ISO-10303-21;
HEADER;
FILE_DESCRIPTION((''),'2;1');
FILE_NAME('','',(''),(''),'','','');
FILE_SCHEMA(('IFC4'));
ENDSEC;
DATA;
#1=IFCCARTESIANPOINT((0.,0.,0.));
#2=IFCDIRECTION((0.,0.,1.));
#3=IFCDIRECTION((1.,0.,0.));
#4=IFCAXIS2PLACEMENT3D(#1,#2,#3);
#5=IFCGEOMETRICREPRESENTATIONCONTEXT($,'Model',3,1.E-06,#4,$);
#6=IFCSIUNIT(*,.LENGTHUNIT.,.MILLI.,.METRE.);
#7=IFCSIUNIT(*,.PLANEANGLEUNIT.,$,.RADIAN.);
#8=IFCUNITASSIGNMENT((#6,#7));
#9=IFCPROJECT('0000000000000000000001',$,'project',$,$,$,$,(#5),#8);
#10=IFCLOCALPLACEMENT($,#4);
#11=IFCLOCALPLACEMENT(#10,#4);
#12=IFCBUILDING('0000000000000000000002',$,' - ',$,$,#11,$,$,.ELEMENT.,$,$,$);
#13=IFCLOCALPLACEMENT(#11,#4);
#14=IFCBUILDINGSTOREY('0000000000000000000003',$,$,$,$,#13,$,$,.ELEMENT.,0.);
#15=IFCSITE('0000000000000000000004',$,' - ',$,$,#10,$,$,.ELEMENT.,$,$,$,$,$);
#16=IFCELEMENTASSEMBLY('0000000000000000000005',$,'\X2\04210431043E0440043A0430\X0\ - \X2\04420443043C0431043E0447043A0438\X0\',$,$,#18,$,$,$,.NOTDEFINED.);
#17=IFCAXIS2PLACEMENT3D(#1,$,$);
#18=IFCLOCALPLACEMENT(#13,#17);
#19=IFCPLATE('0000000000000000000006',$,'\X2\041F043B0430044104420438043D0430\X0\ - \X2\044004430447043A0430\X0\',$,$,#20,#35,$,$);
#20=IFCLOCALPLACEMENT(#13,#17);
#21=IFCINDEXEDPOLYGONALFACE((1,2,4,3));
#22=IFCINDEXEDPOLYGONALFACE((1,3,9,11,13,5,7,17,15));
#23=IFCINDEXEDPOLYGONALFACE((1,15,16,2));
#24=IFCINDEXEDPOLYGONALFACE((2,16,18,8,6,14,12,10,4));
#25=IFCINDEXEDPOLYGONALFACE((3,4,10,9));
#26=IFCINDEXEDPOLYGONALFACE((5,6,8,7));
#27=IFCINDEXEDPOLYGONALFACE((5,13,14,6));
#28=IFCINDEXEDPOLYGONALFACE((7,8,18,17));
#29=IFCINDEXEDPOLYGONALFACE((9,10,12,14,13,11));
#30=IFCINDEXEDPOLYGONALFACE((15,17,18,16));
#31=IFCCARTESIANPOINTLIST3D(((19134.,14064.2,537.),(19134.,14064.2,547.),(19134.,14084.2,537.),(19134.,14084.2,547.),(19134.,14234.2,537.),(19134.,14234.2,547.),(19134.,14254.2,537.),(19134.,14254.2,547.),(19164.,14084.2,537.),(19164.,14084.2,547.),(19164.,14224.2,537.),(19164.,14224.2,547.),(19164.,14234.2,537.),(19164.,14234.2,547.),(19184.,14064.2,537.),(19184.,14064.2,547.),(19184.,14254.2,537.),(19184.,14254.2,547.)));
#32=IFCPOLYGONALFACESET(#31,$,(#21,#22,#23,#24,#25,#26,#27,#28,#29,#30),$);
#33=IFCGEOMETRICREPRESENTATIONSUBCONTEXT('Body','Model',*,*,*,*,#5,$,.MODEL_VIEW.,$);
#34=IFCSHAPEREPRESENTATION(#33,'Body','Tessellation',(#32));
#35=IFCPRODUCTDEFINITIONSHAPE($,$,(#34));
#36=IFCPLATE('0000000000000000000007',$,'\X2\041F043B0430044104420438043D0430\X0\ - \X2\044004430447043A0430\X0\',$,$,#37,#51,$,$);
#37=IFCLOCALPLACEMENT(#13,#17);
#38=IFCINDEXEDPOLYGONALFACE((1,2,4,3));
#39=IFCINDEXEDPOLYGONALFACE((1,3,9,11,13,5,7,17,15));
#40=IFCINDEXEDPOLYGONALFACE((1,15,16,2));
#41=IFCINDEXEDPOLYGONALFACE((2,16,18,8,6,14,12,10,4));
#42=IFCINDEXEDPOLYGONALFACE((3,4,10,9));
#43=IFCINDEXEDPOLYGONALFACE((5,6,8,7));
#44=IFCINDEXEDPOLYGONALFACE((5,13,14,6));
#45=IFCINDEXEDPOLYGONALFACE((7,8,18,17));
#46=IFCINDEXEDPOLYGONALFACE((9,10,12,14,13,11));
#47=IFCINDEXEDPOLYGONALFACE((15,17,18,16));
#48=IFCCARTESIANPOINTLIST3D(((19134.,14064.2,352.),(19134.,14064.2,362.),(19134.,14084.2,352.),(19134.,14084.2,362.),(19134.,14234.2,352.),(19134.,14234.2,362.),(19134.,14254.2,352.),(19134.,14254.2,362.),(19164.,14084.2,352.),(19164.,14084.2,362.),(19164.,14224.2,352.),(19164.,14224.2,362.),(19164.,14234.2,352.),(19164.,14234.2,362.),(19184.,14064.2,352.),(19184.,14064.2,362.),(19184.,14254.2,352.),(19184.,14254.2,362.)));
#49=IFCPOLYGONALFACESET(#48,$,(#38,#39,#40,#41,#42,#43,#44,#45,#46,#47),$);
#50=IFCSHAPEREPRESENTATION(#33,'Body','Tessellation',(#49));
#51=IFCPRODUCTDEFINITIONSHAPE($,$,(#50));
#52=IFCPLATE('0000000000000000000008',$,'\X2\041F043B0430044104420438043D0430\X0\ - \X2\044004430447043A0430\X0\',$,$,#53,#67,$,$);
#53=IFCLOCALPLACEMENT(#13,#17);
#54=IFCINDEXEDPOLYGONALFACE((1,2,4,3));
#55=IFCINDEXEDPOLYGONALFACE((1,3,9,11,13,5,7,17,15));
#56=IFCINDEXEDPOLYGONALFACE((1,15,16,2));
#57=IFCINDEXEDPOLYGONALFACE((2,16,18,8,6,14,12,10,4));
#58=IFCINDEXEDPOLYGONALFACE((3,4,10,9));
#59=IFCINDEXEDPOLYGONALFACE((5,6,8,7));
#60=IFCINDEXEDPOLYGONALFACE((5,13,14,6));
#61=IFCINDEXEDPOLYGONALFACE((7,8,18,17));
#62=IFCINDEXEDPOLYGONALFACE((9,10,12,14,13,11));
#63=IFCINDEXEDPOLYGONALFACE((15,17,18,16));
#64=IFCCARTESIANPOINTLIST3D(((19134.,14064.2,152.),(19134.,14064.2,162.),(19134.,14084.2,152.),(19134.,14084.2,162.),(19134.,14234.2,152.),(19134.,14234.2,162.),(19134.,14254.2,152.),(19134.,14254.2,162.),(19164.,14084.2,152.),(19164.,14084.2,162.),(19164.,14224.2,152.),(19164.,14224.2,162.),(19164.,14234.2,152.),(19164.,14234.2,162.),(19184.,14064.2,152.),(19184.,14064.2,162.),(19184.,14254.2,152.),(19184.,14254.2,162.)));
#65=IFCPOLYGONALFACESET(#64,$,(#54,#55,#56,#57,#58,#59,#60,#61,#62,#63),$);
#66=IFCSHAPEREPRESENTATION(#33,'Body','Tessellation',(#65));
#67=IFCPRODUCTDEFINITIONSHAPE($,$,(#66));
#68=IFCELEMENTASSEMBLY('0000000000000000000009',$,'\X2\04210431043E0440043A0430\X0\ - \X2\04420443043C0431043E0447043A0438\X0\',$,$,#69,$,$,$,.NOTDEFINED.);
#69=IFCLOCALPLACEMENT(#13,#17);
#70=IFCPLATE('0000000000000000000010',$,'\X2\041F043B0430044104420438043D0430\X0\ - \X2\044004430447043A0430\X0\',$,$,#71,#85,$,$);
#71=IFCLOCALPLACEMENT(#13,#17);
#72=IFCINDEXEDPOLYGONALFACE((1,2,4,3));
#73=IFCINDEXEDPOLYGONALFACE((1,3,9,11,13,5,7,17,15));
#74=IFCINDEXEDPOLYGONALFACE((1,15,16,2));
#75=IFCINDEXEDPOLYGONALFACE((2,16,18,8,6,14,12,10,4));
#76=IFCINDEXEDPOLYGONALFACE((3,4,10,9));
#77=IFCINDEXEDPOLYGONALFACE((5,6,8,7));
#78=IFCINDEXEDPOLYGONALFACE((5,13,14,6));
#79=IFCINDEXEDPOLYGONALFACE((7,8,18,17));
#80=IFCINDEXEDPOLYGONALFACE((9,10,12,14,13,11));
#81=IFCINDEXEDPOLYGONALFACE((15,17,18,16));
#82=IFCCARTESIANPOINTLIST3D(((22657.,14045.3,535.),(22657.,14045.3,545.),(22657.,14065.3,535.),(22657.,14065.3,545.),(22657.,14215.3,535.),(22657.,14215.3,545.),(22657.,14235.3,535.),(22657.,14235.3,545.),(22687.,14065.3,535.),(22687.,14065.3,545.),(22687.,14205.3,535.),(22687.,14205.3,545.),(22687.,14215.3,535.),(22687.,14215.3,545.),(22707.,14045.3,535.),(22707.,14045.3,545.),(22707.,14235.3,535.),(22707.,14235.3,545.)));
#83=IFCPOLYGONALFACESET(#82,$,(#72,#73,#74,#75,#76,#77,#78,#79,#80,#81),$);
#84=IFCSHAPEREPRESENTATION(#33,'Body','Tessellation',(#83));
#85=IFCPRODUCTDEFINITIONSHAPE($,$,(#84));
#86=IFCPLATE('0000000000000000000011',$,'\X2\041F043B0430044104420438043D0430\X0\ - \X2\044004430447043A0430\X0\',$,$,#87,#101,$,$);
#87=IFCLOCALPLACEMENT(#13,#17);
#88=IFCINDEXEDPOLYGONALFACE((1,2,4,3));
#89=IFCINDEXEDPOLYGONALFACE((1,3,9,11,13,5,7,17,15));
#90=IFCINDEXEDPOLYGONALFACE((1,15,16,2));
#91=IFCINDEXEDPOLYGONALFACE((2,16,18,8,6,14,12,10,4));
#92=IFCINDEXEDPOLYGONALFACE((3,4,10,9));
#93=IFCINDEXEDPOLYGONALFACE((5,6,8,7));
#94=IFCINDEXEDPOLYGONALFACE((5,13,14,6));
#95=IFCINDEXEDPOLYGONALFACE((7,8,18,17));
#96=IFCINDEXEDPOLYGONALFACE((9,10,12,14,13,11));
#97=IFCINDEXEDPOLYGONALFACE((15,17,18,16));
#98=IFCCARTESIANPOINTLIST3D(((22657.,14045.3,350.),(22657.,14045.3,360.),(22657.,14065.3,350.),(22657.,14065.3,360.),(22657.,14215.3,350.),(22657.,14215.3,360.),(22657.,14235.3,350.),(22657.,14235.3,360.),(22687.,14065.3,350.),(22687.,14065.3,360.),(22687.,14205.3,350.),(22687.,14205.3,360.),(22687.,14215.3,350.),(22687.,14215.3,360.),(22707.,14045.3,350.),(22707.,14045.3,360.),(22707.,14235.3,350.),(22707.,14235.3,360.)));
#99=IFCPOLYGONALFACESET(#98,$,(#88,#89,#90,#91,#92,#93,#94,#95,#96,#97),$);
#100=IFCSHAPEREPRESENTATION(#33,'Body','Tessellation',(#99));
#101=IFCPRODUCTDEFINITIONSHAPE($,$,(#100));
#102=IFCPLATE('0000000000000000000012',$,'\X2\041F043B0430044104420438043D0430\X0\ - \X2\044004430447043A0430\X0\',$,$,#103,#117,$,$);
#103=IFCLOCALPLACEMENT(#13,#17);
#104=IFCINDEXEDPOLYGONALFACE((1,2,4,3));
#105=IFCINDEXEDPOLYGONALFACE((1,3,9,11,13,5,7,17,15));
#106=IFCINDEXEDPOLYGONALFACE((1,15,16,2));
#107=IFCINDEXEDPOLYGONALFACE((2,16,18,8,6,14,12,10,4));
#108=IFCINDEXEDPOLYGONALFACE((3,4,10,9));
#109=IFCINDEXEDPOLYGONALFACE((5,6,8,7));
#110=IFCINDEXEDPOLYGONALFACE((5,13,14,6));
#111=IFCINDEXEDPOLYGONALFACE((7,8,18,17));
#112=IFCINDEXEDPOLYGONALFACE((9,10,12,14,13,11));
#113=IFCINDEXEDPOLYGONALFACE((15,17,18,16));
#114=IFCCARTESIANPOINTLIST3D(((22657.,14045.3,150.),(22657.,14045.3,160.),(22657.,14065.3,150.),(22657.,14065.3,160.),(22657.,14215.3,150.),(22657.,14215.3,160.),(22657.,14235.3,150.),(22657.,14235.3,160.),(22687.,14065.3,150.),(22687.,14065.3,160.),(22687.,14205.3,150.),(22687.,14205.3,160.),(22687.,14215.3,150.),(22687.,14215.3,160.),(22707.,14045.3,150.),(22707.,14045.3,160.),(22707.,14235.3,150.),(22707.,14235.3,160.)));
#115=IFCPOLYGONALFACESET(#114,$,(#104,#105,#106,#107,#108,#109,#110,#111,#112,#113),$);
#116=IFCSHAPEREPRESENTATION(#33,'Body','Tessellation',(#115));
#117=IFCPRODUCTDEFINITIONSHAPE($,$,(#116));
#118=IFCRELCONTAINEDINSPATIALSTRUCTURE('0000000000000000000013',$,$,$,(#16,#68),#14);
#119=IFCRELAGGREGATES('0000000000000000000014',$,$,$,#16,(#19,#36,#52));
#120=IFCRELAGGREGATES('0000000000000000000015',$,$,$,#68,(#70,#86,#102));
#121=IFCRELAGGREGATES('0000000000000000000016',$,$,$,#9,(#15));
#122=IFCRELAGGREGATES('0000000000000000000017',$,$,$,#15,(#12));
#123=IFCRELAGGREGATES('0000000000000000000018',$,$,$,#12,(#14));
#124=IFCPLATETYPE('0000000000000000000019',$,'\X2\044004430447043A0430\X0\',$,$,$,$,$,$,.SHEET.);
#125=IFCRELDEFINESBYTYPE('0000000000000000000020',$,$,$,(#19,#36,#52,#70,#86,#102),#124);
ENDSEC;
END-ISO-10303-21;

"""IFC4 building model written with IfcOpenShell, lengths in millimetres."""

from ifc_helpers import new_model, si_unit, frame, origin_with_axes, place, context, subcontext, project, spatial, line, indexed_curve, outline, extrude, source, transform, mapped, type_object, element, aggregate, save


model = new_model("IFC4")

# Units and contexts
model_context = context("Model", 3, precision=1e-06, world=origin_with_axes())
body_context = subcontext(model_context, "Body", "Model", "MODEL_VIEW")
ifc_project = project(units=[si_unit("LENGTHUNIT", "METRE", prefix="MILLI"), si_unit("PLANEANGLEUNIT", "RADIAN")], contexts=[model_context])

# Site, building, storey
site_placement = place(None, origin_with_axes())
site = spatial("IfcSite", under=ifc_project, at=site_placement, Name=" - ", CompositionType="ELEMENT")
building_placement = place(site_placement, origin_with_axes())
building = spatial("IfcBuilding", under=site, at=building_placement, Name=" - ", CompositionType="ELEMENT")
storey_placement = place(building_placement, origin_with_axes())
storey = spatial("IfcBuildingStorey", under=building, at=storey_placement, CompositionType="ELEMENT", Elevation=0.0)

# Shared definitions
plate_type = type_object("IfcPlateType", Name="ручка", PredefinedType="SHEET")
shared_shape = source(origin_with_axes(), body_context, "Body", "SweptSolid", [
    extrude(outline(indexed_curve([(-95.0, -25.0), (-75.0, -25.0), (-75.0, 5.0), (-65.0, 5.0), (75.0, 5.0), (75.0, -25.0), (95.0, -25.0), (95.0, 25.0), (-95.0, 25.0)], segments=[line(1, 2), line(2, 3), line(3, 4), line(4, 5), line(5, 6), line(6, 7), line(7, 8), line(8, 9), line(9, 1)])), origin_with_axes(), (0.0, 0.0, 1.0), 10.0),
])

# Element assemblies, plates
assembly_1_placement = place(storey_placement, frame((19134.0, 13959.2, 2.0), z_axis=(0.0, 0.0, 1.0), x_axis=(0.0, 1.0, 0.0)))
assembly_1 = element("IfcElementAssembly", 1, at=assembly_1_placement, inside=storey, Name="Сборка - тумбочки", PredefinedType="NOTDEFINED")
plate_1_placement = place(assembly_1_placement, frame((200.0, -25.0, 535.0), z_axis=(0.0, 0.0, 1.0), x_axis=(-1.0, 0.0, 0.0)))
plate_1 = element("IfcPlate", 2, at=plate_1_placement, type_object=plate_type, Name="Пластина - ручка", context=body_context, shape_type="MappedRepresentation", body=[
    mapped(shared_shape, transform((0.0, 0.0, 0.0), x_axis=(1.0, 0.0, 0.0), y_axis=(0.0, 1.0, 0.0), z_axis=(0.0, 0.0, 1.0), scale=1.0)),
])
plate_2_placement = place(assembly_1_placement, frame((200.0, -25.0, 350.0), z_axis=(0.0, 0.0, 1.0), x_axis=(-1.0, 0.0, 0.0)))
plate_2 = element("IfcPlate", 3, at=plate_2_placement, type_object=plate_type, Name="Пластина - ручка", context=body_context, shape_type="MappedRepresentation", body=[
    mapped(shared_shape, transform((0.0, 0.0, 0.0), x_axis=(1.0, 0.0, 0.0), y_axis=(0.0, 1.0, 0.0), z_axis=(0.0, 0.0, 1.0), scale=1.0)),
])
plate_3_placement = place(assembly_1_placement, frame((200.0, -25.0, 150.0), z_axis=(0.0, 0.0, 1.0), x_axis=(-1.0, 0.0, 0.0)))
plate_3 = element("IfcPlate", 4, at=plate_3_placement, type_object=plate_type, Name="Пластина - ручка", context=body_context, shape_type="MappedRepresentation", body=[
    mapped(shared_shape, transform((0.0, 0.0, 0.0), x_axis=(1.0, 0.0, 0.0), y_axis=(0.0, 1.0, 0.0), z_axis=(0.0, 0.0, 1.0), scale=1.0)),
])
aggregate(assembly_1, [plate_1, plate_2, plate_3])
assembly_2_placement = place(storey_placement, frame((22657.0, 13940.3, 0.0), z_axis=(0.0, 0.0, 1.0), x_axis=(0.0, 1.0, 0.0)))
assembly_2 = element("IfcElementAssembly", 5, at=assembly_2_placement, inside=storey, Name="Сборка - тумбочки", PredefinedType="NOTDEFINED")
plate_4_placement = place(assembly_2_placement, frame((200.0, -25.0, 535.0), z_axis=(0.0, 0.0, 1.0), x_axis=(-1.0, 0.0, 0.0)))
plate_4 = element("IfcPlate", 6, at=plate_4_placement, type_object=plate_type, Name="Пластина - ручка", context=body_context, shape_type="MappedRepresentation", body=[
    mapped(shared_shape, transform((0.0, 0.0, 0.0), x_axis=(1.0, 0.0, 0.0), y_axis=(0.0, 1.0, 0.0), z_axis=(0.0, 0.0, 1.0), scale=1.0)),
])
plate_5_placement = place(assembly_2_placement, frame((200.0, -25.0, 350.0), z_axis=(0.0, 0.0, 1.0), x_axis=(-1.0, 0.0, 0.0)))
plate_5 = element("IfcPlate", 7, at=plate_5_placement, type_object=plate_type, Name="Пластина - ручка", context=body_context, shape_type="MappedRepresentation", body=[
    mapped(shared_shape, transform((0.0, 0.0, 0.0), x_axis=(1.0, 0.0, 0.0), y_axis=(0.0, 1.0, 0.0), z_axis=(0.0, 0.0, 1.0), scale=1.0)),
])
plate_6_placement = place(assembly_2_placement, frame((200.0, -25.0, 150.0), z_axis=(0.0, 0.0, 1.0), x_axis=(-1.0, 0.0, 0.0)))
plate_6 = element("IfcPlate", 8, at=plate_6_placement, type_object=plate_type, Name="Пластина - ручка", context=body_context, shape_type="MappedRepresentation", body=[
    mapped(shared_shape, transform((0.0, 0.0, 0.0), x_axis=(1.0, 0.0, 0.0), y_axis=(0.0, 1.0, 0.0), z_axis=(0.0, 0.0, 1.0), scale=1.0)),
])
aggregate(assembly_2, [plate_4, plate_5, plate_6])

save(model, "model.ifc")
